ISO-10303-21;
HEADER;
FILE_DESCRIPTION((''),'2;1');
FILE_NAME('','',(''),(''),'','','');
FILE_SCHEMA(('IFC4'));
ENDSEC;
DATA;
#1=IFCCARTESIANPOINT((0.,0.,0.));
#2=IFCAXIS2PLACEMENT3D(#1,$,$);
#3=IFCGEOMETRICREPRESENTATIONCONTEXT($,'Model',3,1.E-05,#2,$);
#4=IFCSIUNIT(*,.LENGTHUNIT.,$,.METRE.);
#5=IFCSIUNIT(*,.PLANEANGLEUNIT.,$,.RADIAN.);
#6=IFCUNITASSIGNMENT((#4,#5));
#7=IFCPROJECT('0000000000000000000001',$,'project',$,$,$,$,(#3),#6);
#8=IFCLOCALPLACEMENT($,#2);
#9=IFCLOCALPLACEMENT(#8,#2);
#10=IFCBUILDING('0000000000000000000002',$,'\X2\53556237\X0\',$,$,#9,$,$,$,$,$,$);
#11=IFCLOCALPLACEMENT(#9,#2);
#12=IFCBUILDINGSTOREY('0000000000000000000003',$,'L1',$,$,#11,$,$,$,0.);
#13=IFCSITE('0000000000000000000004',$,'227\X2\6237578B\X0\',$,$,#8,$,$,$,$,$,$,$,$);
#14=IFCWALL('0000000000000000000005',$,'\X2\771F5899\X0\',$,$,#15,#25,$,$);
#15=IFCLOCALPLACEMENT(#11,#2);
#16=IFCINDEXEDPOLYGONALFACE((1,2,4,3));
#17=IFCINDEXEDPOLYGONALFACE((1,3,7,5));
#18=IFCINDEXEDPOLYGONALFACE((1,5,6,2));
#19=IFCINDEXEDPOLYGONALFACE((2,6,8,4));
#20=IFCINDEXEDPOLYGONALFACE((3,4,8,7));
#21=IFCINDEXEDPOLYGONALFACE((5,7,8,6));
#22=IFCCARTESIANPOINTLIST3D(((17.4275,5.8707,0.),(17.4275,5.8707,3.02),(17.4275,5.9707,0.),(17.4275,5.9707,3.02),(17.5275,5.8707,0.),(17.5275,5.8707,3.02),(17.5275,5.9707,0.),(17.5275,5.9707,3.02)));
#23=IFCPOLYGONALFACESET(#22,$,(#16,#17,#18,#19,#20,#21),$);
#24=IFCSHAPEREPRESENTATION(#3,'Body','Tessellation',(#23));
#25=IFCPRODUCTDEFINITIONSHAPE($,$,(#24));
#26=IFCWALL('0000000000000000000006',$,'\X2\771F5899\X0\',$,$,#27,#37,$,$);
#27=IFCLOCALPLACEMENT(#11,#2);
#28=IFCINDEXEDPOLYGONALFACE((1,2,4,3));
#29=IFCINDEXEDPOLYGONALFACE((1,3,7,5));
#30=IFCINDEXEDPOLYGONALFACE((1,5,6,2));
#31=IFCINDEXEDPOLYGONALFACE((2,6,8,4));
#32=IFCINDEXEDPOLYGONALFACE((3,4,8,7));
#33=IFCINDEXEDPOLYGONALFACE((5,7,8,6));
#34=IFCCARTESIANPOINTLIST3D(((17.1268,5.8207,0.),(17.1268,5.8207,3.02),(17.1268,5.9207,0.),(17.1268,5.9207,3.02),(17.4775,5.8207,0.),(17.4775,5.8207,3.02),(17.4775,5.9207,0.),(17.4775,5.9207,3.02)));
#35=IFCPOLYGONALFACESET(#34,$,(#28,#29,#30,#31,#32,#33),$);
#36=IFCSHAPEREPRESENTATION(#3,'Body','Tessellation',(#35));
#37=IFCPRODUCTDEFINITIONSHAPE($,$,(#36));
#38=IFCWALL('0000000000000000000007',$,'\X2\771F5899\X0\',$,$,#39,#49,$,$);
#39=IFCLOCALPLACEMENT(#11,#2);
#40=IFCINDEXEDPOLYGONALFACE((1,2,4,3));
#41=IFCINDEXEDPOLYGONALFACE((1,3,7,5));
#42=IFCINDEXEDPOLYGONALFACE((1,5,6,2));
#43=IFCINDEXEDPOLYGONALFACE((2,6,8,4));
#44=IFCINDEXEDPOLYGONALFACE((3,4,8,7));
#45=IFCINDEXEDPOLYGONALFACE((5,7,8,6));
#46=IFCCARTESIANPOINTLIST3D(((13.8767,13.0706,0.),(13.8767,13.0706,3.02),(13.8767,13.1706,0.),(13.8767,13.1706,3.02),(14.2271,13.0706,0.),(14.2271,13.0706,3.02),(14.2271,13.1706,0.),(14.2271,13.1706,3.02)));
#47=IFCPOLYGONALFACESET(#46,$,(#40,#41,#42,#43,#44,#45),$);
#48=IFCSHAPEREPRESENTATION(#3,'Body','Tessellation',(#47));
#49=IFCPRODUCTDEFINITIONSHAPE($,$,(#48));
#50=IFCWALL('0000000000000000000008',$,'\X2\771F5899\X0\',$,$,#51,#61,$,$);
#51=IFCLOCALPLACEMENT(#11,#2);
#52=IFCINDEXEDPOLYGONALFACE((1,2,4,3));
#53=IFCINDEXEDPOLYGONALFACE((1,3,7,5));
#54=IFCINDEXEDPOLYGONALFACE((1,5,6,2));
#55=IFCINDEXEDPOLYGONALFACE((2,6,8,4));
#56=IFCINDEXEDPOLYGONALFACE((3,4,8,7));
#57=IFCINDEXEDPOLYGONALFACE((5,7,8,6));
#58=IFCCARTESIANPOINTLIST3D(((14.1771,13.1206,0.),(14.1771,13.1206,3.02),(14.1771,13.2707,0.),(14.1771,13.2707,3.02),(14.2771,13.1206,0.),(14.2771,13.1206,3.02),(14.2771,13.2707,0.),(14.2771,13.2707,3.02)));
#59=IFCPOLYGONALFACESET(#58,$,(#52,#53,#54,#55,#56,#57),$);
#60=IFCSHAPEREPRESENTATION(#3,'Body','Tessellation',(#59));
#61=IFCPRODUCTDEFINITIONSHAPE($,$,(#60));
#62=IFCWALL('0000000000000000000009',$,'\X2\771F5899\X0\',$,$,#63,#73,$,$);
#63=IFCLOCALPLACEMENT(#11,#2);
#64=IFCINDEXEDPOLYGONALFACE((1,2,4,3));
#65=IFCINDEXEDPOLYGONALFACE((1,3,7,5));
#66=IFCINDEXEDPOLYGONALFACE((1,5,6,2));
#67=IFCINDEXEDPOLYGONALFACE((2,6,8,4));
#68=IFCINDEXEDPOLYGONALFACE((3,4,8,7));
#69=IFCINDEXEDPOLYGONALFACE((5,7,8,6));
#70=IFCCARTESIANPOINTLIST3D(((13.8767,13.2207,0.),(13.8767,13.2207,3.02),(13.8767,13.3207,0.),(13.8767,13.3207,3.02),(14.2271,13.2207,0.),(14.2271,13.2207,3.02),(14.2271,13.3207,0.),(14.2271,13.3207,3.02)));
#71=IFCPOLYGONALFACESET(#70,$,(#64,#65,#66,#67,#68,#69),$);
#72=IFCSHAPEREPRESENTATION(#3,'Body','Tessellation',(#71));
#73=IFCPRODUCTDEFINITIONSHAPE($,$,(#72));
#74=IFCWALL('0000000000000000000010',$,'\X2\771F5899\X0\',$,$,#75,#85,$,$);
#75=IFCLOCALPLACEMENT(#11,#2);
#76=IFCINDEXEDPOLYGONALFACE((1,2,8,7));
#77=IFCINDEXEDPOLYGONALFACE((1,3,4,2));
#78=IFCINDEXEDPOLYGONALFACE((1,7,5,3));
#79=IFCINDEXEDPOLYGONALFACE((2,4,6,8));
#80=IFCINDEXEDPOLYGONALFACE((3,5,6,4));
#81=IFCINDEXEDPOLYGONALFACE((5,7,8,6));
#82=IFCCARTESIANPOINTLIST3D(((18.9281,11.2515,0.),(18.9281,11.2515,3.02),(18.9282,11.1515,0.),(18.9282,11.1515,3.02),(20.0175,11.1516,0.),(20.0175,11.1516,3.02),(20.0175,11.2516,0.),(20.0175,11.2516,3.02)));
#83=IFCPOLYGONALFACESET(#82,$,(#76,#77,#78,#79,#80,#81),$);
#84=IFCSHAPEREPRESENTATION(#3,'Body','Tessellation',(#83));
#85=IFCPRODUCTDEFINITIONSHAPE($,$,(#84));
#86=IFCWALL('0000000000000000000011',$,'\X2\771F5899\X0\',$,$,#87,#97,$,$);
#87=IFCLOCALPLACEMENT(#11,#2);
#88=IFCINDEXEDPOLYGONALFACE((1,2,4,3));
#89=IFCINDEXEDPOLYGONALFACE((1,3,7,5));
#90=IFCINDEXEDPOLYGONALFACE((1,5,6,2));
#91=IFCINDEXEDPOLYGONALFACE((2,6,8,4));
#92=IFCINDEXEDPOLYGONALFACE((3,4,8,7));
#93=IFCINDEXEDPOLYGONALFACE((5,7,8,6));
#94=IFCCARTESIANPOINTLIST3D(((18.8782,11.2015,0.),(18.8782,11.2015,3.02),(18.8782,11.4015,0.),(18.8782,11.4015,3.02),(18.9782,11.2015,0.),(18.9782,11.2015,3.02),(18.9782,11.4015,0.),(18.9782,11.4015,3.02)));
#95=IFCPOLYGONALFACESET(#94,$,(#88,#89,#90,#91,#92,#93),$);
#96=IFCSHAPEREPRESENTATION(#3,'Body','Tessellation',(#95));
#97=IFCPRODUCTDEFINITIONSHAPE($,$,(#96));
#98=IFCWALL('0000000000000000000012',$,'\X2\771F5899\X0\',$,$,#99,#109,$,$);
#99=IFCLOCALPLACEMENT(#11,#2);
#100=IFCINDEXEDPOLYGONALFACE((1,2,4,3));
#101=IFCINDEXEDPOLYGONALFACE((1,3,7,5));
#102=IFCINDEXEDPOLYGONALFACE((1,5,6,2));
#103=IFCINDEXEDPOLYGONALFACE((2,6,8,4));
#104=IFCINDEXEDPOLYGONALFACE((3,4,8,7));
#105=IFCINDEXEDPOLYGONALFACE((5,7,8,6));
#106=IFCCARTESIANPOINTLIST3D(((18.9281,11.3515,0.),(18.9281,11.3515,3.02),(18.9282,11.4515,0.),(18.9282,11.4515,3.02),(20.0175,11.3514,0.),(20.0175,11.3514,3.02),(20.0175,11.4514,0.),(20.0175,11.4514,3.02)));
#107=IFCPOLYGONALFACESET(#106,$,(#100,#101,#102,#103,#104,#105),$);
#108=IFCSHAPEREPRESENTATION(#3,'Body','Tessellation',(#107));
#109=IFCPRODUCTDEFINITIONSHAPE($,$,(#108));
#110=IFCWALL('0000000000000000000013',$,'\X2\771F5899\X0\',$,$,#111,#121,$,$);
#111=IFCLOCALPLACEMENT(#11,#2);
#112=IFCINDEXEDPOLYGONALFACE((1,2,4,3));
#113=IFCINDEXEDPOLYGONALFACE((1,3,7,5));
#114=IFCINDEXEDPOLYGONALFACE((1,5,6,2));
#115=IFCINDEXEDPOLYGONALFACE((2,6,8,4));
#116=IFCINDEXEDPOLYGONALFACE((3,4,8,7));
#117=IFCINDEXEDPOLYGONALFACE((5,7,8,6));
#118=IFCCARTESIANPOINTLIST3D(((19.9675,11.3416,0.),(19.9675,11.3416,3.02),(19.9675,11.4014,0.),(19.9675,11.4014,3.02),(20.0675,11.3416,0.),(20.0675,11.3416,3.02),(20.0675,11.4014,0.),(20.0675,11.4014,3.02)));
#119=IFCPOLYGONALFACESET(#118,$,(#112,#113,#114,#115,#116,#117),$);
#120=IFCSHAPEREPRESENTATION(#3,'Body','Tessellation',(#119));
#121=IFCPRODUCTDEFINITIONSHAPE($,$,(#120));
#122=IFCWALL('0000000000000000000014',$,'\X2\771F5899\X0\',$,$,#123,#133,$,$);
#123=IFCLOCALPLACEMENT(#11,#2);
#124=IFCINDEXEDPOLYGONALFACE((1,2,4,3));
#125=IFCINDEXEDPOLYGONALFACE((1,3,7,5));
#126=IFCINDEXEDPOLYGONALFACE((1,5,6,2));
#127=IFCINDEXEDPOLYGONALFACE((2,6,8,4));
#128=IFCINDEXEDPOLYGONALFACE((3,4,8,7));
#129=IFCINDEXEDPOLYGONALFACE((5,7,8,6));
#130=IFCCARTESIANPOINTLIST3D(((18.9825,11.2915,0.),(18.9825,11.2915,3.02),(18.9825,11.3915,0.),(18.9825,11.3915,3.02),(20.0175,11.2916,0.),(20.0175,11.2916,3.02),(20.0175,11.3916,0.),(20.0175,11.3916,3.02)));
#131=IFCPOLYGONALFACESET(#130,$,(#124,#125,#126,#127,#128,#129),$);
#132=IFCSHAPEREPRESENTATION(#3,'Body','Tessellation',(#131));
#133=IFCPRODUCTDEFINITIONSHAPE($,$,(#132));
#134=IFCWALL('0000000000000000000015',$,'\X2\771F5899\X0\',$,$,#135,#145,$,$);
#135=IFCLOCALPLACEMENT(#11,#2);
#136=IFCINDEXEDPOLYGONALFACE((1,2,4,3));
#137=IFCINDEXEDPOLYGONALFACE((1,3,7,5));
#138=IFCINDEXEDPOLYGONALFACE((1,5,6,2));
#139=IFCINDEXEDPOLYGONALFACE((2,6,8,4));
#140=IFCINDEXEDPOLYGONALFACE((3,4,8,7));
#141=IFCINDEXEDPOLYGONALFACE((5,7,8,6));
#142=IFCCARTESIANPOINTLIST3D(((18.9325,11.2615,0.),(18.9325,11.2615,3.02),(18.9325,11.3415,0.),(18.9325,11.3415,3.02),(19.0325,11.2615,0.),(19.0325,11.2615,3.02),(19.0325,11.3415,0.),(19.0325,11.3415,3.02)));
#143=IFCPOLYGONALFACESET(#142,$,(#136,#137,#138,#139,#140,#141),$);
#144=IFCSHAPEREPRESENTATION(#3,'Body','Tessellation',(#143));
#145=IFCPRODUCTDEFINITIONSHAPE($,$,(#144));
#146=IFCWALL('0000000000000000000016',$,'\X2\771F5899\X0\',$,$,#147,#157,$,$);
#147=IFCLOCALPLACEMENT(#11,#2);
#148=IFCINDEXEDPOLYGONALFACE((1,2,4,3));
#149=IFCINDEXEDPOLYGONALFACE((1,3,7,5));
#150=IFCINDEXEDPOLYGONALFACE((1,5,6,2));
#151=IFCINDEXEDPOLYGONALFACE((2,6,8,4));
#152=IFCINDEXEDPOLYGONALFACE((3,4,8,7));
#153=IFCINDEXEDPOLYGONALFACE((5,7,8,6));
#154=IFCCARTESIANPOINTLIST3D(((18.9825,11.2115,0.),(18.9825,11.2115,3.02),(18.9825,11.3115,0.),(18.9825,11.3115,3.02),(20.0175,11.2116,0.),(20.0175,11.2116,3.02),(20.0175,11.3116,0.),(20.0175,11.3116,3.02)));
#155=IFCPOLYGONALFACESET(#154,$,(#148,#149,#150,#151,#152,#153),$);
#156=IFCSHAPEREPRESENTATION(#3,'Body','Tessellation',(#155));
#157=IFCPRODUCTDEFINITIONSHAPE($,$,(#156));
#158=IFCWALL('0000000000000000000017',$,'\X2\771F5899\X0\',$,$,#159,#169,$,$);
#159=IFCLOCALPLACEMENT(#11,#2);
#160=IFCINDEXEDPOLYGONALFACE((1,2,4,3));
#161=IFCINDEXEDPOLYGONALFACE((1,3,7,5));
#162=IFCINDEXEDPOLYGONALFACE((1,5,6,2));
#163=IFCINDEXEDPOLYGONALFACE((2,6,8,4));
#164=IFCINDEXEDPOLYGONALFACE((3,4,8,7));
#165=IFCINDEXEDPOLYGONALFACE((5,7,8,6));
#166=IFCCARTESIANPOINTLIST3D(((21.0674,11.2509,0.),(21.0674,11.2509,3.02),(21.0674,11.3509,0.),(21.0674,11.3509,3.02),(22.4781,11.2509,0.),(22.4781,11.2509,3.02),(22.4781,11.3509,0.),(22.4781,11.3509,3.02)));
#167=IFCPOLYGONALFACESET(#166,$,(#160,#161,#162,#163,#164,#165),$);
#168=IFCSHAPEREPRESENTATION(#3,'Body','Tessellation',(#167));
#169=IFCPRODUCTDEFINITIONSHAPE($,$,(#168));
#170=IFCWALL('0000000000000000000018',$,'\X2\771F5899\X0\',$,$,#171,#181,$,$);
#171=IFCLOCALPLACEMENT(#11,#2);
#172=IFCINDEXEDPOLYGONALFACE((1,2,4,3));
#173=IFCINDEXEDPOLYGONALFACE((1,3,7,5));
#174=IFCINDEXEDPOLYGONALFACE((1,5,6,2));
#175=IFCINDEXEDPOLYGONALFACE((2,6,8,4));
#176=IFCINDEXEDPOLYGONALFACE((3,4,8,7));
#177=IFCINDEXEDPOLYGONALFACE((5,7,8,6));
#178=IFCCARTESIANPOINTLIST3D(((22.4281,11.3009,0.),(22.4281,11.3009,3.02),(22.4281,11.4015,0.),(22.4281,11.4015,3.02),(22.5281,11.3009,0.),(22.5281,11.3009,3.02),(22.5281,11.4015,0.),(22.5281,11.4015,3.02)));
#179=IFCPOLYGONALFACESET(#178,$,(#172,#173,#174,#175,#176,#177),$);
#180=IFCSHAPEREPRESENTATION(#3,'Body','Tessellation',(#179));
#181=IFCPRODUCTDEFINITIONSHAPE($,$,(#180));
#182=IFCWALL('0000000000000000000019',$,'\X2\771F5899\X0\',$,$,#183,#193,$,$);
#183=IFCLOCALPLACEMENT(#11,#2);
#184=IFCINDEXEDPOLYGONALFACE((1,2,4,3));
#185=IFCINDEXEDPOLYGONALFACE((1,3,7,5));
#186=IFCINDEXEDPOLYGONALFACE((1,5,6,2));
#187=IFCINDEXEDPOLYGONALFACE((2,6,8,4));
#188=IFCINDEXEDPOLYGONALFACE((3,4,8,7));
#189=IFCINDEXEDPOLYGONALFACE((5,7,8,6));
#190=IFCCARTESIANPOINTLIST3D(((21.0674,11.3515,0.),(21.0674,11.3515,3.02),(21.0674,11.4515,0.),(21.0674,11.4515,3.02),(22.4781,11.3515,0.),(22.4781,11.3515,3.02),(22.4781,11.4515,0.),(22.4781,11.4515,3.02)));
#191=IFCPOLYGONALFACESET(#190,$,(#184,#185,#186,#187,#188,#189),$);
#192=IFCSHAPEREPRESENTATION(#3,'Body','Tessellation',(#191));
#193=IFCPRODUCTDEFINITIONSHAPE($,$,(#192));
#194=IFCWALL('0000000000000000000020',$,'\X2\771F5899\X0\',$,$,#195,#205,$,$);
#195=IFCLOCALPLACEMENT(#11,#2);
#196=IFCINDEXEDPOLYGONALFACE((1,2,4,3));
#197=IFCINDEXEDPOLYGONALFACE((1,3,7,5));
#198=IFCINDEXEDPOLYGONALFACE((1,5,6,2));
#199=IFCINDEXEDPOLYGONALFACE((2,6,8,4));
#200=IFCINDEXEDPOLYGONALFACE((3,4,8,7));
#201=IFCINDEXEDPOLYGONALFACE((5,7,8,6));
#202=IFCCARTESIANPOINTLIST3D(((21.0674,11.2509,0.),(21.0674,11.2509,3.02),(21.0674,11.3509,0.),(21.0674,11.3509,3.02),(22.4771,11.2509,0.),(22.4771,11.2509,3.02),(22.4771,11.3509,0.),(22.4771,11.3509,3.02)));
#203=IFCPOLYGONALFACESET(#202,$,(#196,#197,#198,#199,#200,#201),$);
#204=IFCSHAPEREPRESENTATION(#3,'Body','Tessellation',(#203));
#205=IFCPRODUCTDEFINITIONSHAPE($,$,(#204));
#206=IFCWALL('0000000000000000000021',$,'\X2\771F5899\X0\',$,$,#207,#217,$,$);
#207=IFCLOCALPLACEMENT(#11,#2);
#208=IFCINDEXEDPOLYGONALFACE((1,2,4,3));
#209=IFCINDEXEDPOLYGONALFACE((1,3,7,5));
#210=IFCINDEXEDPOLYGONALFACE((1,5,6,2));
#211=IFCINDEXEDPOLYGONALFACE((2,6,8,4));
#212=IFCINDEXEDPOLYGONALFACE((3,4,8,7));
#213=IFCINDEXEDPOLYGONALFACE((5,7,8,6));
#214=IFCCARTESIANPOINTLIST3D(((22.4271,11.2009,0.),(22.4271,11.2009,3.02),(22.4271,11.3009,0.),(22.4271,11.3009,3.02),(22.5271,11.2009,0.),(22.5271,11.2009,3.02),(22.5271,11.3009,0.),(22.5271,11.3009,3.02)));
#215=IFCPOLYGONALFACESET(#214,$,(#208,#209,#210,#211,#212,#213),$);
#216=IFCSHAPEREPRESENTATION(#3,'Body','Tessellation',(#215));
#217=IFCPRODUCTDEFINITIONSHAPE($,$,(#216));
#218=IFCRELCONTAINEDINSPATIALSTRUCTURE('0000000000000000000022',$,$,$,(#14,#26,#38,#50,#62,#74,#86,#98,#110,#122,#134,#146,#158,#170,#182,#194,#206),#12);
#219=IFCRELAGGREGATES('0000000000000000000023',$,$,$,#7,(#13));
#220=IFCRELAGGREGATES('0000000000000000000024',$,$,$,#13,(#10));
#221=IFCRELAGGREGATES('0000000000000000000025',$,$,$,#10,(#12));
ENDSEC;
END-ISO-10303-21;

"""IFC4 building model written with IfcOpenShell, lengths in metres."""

from ifc_helpers import new_model, si_unit, origin, place, context, project, spatial, polyline, outline, extrude, element, save


model = new_model("IFC4")

# Units and contexts
model_context = context("Model", 3, precision=1e-05, world=origin())
ifc_project = project(units=[si_unit("LENGTHUNIT", "METRE"), si_unit("PLANEANGLEUNIT", "RADIAN")], contexts=[model_context])

# Site, building, storey
site_placement = place(None, origin())
site = spatial("IfcSite", under=ifc_project, at=site_placement, Name="227户型")
building_placement = place(site_placement, origin())
building = spatial("IfcBuilding", under=site, at=building_placement, Name="单户")
storey_placement = place(building_placement, origin())
storey = spatial("IfcBuildingStorey", under=building, at=storey_placement, Name="L1", Elevation=0.0)

# Walls
wall_1_placement = place(storey_placement, origin())
element("IfcWall", 1, at=wall_1_placement, inside=storey, Name="真墙", context=model_context, shape_type="SweptSolid", body=[
    extrude(outline(polyline([(17.5275, 5.9707), (17.5275, 5.8707), (17.4275, 5.8707), (17.4275, 5.9707), (17.5275, 5.9707)])), origin(), (0.0, 0.0, 1.0), 3.02),
])
wall_2_placement = place(storey_placement, origin())
element("IfcWall", 2, at=wall_2_placement, inside=storey, Name="真墙", context=model_context, shape_type="SweptSolid", body=[
    extrude(outline(polyline([(17.4775, 5.8207), (17.1268, 5.8207), (17.1268, 5.9207), (17.4775, 5.9207), (17.4775, 5.8207)])), origin(), (0.0, 0.0, 1.0), 3.02),
])
wall_3_placement = place(storey_placement, origin())
element("IfcWall", 3, at=wall_3_placement, inside=storey, Name="真墙", context=model_context, shape_type="SweptSolid", body=[
    extrude(outline(polyline([(13.8767, 13.1706), (14.2271, 13.1706), (14.2271, 13.0706), (13.8767, 13.0706), (13.8767, 13.1706)])), origin(), (0.0, 0.0, 1.0), 3.02),
])
wall_4_placement = place(storey_placement, origin())
element("IfcWall", 4, at=wall_4_placement, inside=storey, Name="真墙", context=model_context, shape_type="SweptSolid", body=[
    extrude(outline(polyline([(14.1771, 13.1206), (14.1771, 13.2707), (14.2771, 13.2707), (14.2771, 13.1206), (14.1771, 13.1206)])), origin(), (0.0, 0.0, 1.0), 3.02),
])
wall_5_placement = place(storey_placement, origin())
element("IfcWall", 5, at=wall_5_placement, inside=storey, Name="真墙", context=model_context, shape_type="SweptSolid", body=[
    extrude(outline(polyline([(14.2271, 13.2207), (13.8767, 13.2207), (13.8767, 13.3207), (14.2271, 13.3207), (14.2271, 13.2207)])), origin(), (0.0, 0.0, 1.0), 3.02),
])
wall_6_placement = place(storey_placement, origin())
element("IfcWall", 6, at=wall_6_placement, inside=storey, Name="真墙", context=model_context, shape_type="SweptSolid", body=[
    extrude(outline(polyline([(20.0175, 11.1516), (18.9282, 11.1515), (18.9281, 11.2515), (20.0175, 11.2516), (20.0175, 11.1516)])), origin(), (0.0, 0.0, 1.0), 3.02),
])
wall_7_placement = place(storey_placement, origin())
element("IfcWall", 7, at=wall_7_placement, inside=storey, Name="真墙", context=model_context, shape_type="SweptSolid", body=[
    extrude(outline(polyline([(18.8782, 11.2015), (18.8782, 11.4015), (18.9782, 11.4015), (18.9782, 11.2015), (18.8782, 11.2015)])), origin(), (0.0, 0.0, 1.0), 3.02),
])
wall_8_placement = place(storey_placement, origin())
element("IfcWall", 8, at=wall_8_placement, inside=storey, Name="真墙", context=model_context, shape_type="SweptSolid", body=[
    extrude(outline(polyline([(18.9282, 11.4515), (20.0175, 11.4514), (20.0175, 11.3514), (18.9281, 11.3515), (18.9282, 11.4515)])), origin(), (0.0, 0.0, 1.0), 3.02),
])
wall_9_placement = place(storey_placement, origin())
element("IfcWall", 9, at=wall_9_placement, inside=storey, Name="真墙", context=model_context, shape_type="SweptSolid", body=[
    extrude(outline(polyline([(20.0675, 11.4014), (20.0675, 11.3416), (19.9675, 11.3416), (19.9675, 11.4014), (20.0675, 11.4014)])), origin(), (0.0, 0.0, 1.0), 3.02),
])
wall_10_placement = place(storey_placement, origin())
element("IfcWall", 10, at=wall_10_placement, inside=storey, Name="真墙", context=model_context, shape_type="SweptSolid", body=[
    extrude(outline(polyline([(20.0175, 11.2916), (18.9825, 11.2915), (18.9825, 11.3915), (20.0175, 11.3916), (20.0175, 11.2916)])), origin(), (0.0, 0.0, 1.0), 3.02),
])
wall_11_placement = place(storey_placement, origin())
element("IfcWall", 11, at=wall_11_placement, inside=storey, Name="真墙", context=model_context, shape_type="SweptSolid", body=[
    extrude(outline(polyline([(19.0325, 11.3415), (19.0325, 11.2615), (18.9325, 11.2615), (18.9325, 11.3415), (19.0325, 11.3415)])), origin(), (0.0, 0.0, 1.0), 3.02),
])
wall_12_placement = place(storey_placement, origin())
element("IfcWall", 12, at=wall_12_placement, inside=storey, Name="真墙", context=model_context, shape_type="SweptSolid", body=[
    extrude(outline(polyline([(18.9825, 11.3115), (20.0175, 11.3116), (20.0175, 11.2116), (18.9825, 11.2115), (18.9825, 11.3115)])), origin(), (0.0, 0.0, 1.0), 3.02),
])
wall_13_placement = place(storey_placement, origin())
element("IfcWall", 13, at=wall_13_placement, inside=storey, Name="真墙", context=model_context, shape_type="SweptSolid", body=[
    extrude(outline(polyline([(21.0674, 11.3509), (22.4781, 11.3509), (22.4781, 11.2509), (21.0674, 11.2509), (21.0674, 11.3509)])), origin(), (0.0, 0.0, 1.0), 3.02),
])
wall_14_placement = place(storey_placement, origin())
element("IfcWall", 14, at=wall_14_placement, inside=storey, Name="真墙", context=model_context, shape_type="SweptSolid", body=[
    extrude(outline(polyline([(22.4281, 11.3009), (22.4281, 11.4015), (22.5281, 11.4015), (22.5281, 11.3009), (22.4281, 11.3009)])), origin(), (0.0, 0.0, 1.0), 3.02),
])
wall_15_placement = place(storey_placement, origin())
element("IfcWall", 15, at=wall_15_placement, inside=storey, Name="真墙", context=model_context, shape_type="SweptSolid", body=[
    extrude(outline(polyline([(22.4781, 11.3515), (21.0674, 11.3515), (21.0674, 11.4515), (22.4781, 11.4515), (22.4781, 11.3515)])), origin(), (0.0, 0.0, 1.0), 3.02),
])
wall_16_placement = place(storey_placement, origin())
element("IfcWall", 16, at=wall_16_placement, inside=storey, Name="真墙", context=model_context, shape_type="SweptSolid", body=[
    extrude(outline(polyline([(21.0674, 11.3509), (22.4771, 11.3509), (22.4771, 11.2509), (21.0674, 11.2509), (21.0674, 11.3509)])), origin(), (0.0, 0.0, 1.0), 3.02),
])
wall_17_placement = place(storey_placement, origin())
element("IfcWall", 17, at=wall_17_placement, inside=storey, Name="真墙", context=model_context, shape_type="SweptSolid", body=[
    extrude(outline(polyline([(22.5271, 11.3009), (22.5271, 11.2009), (22.4271, 11.2009), (22.4271, 11.3009), (22.5271, 11.3009)])), origin(), (0.0, 0.0, 1.0), 3.02),
])

save(model, "model.ifc")
